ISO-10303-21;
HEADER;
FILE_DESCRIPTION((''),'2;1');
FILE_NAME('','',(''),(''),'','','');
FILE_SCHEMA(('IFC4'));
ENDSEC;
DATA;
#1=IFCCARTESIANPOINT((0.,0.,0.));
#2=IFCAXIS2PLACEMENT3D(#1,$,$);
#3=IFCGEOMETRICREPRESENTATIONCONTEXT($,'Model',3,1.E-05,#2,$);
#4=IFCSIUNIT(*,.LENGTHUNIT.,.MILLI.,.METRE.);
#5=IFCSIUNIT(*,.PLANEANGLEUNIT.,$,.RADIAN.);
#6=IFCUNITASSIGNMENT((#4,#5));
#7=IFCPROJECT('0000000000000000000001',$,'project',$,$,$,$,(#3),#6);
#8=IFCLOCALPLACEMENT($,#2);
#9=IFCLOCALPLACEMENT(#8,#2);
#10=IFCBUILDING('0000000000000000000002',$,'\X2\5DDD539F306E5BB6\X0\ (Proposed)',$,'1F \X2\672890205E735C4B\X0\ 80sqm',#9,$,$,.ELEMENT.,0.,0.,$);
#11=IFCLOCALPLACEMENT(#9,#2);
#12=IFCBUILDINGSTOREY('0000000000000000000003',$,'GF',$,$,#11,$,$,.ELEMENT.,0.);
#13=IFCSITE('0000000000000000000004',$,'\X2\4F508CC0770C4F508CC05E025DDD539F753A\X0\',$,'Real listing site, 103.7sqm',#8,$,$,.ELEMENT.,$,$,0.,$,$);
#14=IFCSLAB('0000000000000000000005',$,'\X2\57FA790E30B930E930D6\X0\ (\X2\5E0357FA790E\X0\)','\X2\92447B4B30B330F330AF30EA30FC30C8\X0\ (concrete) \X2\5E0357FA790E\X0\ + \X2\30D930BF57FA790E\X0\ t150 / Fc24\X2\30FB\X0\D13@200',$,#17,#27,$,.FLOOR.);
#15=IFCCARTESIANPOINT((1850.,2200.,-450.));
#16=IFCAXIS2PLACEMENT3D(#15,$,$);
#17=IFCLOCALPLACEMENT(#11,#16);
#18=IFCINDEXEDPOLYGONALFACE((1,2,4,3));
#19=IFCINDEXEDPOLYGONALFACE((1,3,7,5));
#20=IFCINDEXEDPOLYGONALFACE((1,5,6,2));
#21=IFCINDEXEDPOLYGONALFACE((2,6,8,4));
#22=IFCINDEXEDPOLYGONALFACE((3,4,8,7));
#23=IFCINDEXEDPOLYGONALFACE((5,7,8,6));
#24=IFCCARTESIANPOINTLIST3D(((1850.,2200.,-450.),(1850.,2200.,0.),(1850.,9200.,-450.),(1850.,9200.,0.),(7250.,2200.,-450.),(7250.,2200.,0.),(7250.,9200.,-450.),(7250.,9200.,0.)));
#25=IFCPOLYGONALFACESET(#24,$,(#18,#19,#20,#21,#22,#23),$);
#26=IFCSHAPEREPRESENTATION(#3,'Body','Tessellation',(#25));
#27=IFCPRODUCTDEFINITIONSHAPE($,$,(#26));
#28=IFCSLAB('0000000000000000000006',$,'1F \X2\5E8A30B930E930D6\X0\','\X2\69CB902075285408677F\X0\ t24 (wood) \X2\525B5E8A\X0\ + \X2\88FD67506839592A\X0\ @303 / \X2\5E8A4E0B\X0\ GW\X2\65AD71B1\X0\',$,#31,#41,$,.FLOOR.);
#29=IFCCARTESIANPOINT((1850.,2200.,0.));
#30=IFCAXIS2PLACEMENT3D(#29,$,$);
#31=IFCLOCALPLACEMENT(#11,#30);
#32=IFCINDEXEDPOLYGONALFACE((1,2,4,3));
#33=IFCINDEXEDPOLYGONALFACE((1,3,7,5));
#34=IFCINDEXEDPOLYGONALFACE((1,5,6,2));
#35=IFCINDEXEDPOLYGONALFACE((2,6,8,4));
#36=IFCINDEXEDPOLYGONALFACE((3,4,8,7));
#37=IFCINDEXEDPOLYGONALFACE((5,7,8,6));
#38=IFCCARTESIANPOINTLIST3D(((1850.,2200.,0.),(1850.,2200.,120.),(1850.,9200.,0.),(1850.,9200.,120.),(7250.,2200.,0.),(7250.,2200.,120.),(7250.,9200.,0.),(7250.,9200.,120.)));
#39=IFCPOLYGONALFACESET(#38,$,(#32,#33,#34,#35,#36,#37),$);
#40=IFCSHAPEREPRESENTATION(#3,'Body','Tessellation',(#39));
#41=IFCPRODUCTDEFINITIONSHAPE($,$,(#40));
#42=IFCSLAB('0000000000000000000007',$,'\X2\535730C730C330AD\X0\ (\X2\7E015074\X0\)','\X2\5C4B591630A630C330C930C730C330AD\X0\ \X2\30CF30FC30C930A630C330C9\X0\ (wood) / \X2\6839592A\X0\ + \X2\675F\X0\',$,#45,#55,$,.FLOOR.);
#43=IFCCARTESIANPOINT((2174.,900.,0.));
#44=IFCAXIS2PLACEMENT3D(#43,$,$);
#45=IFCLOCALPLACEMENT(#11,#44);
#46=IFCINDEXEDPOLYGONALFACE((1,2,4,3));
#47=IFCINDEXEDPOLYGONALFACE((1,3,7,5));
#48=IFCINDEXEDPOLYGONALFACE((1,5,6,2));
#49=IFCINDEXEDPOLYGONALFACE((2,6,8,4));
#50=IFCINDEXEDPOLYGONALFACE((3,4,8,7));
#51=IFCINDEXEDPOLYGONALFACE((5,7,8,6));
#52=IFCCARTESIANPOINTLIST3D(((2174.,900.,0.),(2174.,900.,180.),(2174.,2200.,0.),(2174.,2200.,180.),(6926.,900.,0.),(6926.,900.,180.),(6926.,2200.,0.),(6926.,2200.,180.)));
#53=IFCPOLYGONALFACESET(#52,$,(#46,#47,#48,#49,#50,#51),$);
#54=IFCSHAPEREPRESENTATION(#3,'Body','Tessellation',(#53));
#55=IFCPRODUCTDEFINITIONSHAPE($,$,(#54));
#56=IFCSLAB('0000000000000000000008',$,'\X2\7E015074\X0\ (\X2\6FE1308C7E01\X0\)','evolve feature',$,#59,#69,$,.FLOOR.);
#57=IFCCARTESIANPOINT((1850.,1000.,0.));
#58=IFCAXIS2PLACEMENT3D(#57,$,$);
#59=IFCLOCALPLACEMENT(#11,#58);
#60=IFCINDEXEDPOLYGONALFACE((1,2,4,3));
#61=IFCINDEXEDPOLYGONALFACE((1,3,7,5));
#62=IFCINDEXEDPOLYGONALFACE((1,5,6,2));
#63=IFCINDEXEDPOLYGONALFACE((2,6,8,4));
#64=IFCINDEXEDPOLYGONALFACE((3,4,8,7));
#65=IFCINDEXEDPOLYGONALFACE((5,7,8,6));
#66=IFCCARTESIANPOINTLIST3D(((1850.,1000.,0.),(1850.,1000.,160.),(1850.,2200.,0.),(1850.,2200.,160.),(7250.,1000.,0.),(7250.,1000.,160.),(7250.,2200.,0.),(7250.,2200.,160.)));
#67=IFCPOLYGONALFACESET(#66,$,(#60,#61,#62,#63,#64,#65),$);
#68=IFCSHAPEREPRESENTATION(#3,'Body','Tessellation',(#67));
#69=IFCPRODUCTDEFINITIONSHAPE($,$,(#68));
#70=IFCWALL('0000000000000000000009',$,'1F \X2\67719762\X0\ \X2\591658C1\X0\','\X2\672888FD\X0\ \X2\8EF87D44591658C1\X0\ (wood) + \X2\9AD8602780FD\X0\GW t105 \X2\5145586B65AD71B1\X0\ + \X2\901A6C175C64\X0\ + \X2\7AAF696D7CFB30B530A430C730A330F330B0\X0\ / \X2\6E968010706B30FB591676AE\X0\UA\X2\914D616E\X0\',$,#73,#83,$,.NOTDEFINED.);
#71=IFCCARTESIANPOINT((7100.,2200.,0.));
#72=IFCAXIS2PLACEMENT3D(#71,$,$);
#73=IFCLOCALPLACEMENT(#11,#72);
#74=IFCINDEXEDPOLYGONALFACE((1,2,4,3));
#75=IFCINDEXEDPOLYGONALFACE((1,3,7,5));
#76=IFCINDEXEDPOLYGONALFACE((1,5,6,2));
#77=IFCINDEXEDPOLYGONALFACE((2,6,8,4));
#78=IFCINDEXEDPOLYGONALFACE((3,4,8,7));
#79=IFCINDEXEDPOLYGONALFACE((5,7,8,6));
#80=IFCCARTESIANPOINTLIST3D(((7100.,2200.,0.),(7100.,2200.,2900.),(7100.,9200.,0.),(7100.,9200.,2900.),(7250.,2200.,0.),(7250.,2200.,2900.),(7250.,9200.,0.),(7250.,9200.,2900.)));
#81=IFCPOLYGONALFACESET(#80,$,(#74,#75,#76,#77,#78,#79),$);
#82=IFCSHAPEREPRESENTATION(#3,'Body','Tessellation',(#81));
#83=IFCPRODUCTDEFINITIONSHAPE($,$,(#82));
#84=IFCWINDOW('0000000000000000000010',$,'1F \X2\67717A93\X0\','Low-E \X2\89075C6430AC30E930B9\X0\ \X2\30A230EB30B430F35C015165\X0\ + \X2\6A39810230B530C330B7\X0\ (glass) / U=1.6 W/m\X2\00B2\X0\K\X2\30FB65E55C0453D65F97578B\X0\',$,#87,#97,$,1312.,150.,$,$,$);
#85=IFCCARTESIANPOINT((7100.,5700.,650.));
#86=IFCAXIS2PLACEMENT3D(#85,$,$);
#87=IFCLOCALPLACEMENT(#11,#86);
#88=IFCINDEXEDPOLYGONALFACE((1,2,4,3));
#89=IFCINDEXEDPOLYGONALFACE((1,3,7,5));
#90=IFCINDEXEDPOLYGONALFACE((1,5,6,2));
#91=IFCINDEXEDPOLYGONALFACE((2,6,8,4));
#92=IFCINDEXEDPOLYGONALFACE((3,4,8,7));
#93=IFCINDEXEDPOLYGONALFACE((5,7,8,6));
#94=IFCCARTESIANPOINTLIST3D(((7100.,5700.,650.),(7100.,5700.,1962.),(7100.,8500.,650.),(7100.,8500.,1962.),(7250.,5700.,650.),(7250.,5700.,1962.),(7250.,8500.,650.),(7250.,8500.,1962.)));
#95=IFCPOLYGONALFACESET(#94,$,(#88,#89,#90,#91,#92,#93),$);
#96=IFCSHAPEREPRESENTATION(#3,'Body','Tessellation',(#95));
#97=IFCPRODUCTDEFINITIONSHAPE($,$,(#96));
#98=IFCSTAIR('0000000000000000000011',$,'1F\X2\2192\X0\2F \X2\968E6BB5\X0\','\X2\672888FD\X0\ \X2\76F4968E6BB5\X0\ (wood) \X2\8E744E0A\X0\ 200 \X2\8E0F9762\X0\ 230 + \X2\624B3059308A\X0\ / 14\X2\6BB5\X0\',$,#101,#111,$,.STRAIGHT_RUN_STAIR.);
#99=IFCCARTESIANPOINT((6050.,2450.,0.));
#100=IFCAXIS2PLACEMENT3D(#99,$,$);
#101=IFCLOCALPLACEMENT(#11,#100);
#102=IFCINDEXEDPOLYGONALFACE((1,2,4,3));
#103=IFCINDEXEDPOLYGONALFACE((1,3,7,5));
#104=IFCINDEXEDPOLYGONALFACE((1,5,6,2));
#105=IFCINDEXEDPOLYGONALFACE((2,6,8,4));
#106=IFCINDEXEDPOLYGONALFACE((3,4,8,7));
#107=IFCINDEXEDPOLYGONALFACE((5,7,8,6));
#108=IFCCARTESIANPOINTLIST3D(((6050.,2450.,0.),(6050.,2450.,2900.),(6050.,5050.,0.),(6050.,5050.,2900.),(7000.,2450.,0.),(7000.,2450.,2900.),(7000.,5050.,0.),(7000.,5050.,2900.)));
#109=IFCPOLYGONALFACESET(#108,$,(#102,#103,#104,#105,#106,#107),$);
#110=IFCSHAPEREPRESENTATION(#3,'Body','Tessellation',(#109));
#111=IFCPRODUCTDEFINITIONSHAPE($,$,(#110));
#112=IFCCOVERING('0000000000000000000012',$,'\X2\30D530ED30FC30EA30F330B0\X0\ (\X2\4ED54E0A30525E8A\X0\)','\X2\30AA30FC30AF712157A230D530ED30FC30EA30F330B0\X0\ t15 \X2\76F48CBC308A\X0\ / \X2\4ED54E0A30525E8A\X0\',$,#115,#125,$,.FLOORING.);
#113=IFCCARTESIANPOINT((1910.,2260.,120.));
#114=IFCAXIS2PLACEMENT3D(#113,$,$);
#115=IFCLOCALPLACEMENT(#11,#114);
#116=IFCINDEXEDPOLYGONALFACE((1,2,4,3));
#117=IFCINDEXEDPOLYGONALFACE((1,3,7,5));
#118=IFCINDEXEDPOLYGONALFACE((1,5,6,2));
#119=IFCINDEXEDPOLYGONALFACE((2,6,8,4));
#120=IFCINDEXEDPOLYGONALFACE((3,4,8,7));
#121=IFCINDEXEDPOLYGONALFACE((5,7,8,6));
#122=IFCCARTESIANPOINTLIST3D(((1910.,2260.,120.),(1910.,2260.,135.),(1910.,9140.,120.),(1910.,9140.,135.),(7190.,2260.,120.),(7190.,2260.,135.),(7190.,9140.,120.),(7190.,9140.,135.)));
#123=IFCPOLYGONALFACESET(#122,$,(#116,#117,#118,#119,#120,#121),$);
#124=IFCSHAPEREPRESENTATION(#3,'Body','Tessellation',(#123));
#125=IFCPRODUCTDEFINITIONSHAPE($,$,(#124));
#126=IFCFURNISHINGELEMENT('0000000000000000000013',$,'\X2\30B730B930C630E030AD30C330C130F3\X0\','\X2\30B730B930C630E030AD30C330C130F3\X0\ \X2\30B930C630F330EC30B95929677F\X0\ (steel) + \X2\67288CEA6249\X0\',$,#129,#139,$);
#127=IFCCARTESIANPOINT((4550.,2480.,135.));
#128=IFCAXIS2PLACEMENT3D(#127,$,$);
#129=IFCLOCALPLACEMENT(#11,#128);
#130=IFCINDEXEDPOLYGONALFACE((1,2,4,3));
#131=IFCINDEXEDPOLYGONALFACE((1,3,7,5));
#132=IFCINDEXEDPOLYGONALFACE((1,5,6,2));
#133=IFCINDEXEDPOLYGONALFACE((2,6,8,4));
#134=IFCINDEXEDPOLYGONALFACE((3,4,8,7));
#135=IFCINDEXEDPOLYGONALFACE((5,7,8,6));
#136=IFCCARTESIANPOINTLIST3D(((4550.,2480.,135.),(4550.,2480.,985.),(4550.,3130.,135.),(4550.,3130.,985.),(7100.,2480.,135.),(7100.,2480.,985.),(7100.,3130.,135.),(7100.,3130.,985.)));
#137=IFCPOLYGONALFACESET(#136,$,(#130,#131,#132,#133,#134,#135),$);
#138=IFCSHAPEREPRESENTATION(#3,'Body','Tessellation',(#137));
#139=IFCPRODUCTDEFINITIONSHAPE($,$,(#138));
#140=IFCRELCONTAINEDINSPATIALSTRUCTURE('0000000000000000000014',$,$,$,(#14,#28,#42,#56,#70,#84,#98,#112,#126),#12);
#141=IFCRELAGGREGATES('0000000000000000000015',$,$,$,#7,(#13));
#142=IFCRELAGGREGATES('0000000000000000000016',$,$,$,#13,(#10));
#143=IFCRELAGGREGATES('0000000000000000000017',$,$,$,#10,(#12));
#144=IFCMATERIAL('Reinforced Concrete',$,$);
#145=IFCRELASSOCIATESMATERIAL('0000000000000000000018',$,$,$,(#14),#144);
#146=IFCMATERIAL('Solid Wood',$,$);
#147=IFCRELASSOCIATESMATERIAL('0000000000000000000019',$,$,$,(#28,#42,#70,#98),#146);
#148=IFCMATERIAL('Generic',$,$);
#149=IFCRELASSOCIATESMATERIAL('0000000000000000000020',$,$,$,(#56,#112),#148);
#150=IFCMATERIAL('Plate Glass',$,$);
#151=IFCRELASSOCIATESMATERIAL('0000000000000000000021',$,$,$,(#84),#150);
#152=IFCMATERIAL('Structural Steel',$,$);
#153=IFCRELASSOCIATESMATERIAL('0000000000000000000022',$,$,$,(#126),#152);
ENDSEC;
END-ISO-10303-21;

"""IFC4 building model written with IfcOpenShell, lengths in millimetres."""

from ifc_helpers import new_model, si_unit, frame, frame_2d, origin, place, context, project, spatial, rectangle, extrude, material, element, fill, save


model = new_model("IFC4")

# Units and contexts
model_context = context("Model", 3, precision=1e-05, world=origin())
ifc_project = project(units=[si_unit("LENGTHUNIT", "METRE", prefix="MILLI"), si_unit("PLANEANGLEUNIT", "RADIAN")], contexts=[model_context])

# Site, building, storey
site_placement = place(None, origin())
site = spatial("IfcSite", under=ifc_project, at=site_placement, Name="佐賀県佐賀市川原町", ObjectType="Real listing site, 103.7sqm", CompositionType="ELEMENT", RefElevation=0.0)
building_placement = place(site_placement, origin())
building = spatial("IfcBuilding", under=site, at=building_placement, Name="川原の家 (Proposed)", ObjectType="1F 木造平屋 80sqm", CompositionType="ELEMENT", ElevationOfRefHeight=0.0, ElevationOfTerrain=0.0)
storey_placement = place(building_placement, origin())
storey = spatial("IfcBuildingStorey", under=building, at=storey_placement, Name="GF", CompositionType="ELEMENT", Elevation=0.0)

# Slabs
ifc_material_1 = material(Name="Reinforced Concrete")
slab_1_placement = place(storey_placement, frame((1850.0, 2200.0, -450.0)))
element("IfcSlab", 1, at=slab_1_placement, inside=storey, material=ifc_material_1, Name="基礎スラブ (布基礎)", Description="鉄筋コンクリート (concrete) 布基礎 + ベタ基礎 t150 / Fc24・D13@200", PredefinedType="FLOOR", context=model_context, shape_type="SweptSolid", body=[
    extrude(rectangle(XDim=5400.0, YDim=7000.0, at=frame_2d((2700.0, 3500.0))), frame((1850.0, 2200.0, -450.0)), (0.0, 0.0, 1.0), 450.0),
])
ifc_material_2 = material(Name="Solid Wood")
slab_2_placement = place(storey_placement, frame((1850.0, 2200.0, 0.0)))
element("IfcSlab", 2, at=slab_2_placement, inside=storey, material=ifc_material_2, Name="1F 床スラブ", Description="構造用合板 t24 (wood) 剛床 + 製材根太 @303 / 床下 GW断熱", PredefinedType="FLOOR", context=model_context, shape_type="SweptSolid", body=[
    extrude(rectangle(XDim=5400.0, YDim=7000.0, at=frame_2d((2700.0, 3500.0))), frame((1850.0, 2200.0, 0.0)), (0.0, 0.0, 1.0), 120.0),
])
slab_3_placement = place(storey_placement, frame((2174.0, 900.0, 0.0)))
element("IfcSlab", 3, at=slab_3_placement, inside=storey, material=ifc_material_2, Name="南デッキ (縁側)", Description="屋外ウッドデッキ ハードウッド (wood) / 根太 + 束", PredefinedType="FLOOR", context=model_context, shape_type="SweptSolid", body=[
    extrude(rectangle(XDim=4752.0, YDim=1300.0, at=frame_2d((2376.0, 650.0))), frame((2174.0, 900.0, 0.0)), (0.0, 0.0, 1.0), 180.0),
])
ifc_material_3 = material(Name="Generic")
slab_4_placement = place(storey_placement, frame((1850.0, 1000.0, 0.0)))
element("IfcSlab", 4, at=slab_4_placement, inside=storey, material=ifc_material_3, Name="縁側 (濡れ縁)", Description="evolve feature", PredefinedType="FLOOR", context=model_context, shape_type="SweptSolid", body=[
    extrude(rectangle(XDim=5400.0, YDim=1200.0, at=frame_2d((2700.0, 600.0))), frame((1850.0, 1000.0, 0.0)), (0.0, 0.0, 1.0), 160.0),
])

# Shared definitions
ifc_material_4 = material(Name="Plate Glass")

# Wall, opening, window
wall_1_placement = place(storey_placement, frame((7100.0, 2200.0, 0.0)))
wall_1 = element("IfcWall", 5, at=wall_1_placement, inside=storey, material=ifc_material_2, Name="1F 東面 外壁", Description="木製 軸組外壁 (wood) + 高性能GW t105 充填断熱 + 通気層 + 窯業系サイディング / 準耐火・外皮UA配慮", PredefinedType="NOTDEFINED", context=model_context, shape_type="SweptSolid", body=[
    extrude(rectangle(XDim=150.0, YDim=7000.0, at=frame_2d((75.0, 3500.0))), frame((7100.0, 2200.0, 0.0)), (0.0, 0.0, 1.0), 2900.0),
])
opening_1_placement = place(storey_placement, frame((7100.0, 5700.0, 650.0)))
opening_1 = element("IfcOpeningElement", 6, at=opening_1_placement, cuts=wall_1, PredefinedType="NOTDEFINED", context=model_context, shape_type="SweptSolid", body=[
    extrude(rectangle(XDim=150.0, YDim=2800.0, at=frame_2d((75.0, 1400.0))), frame((7100.0, 5700.0, 650.0)), (0.0, 0.0, 1.0), 1312.0),
])
window_1_placement = place(storey_placement, frame((7100.0, 5700.0, 650.0)))
window_1 = element("IfcWindow", 7, at=window_1_placement, inside=storey, material=ifc_material_4, Name="1F 東窓", Description="Low-E 複層ガラス アルゴン封入 + 樹脂サッシ (glass) / U=1.6 W/m²K・日射取得型", OverallHeight=1312.0, OverallWidth=150.0, context=model_context, shape_type="SweptSolid", body=[
    extrude(rectangle(XDim=150.0, YDim=2800.0, at=frame_2d((75.0, 1400.0))), frame((7100.0, 5700.0, 650.0)), (0.0, 0.0, 1.0), 1312.0),
])
fill(opening_1, window_1)

# Stair
stair_placement = place(storey_placement, frame((6050.0, 2450.0, 0.0)))
element("IfcStair", 8, at=stair_placement, inside=storey, material=ifc_material_2, Name="1F→2F 階段", Description="木製 直階段 (wood) 蹴上 200 踏面 230 + 手すり / 14段", PredefinedType="STRAIGHT_RUN_STAIR", context=model_context, shape_type="SweptSolid", body=[
    extrude(rectangle(XDim=950.0, YDim=2600.0, at=frame_2d((475.0, 1300.0))), frame((6050.0, 2450.0, 0.0)), (0.0, 0.0, 1.0), 2900.0),
])

# Covering
covering_placement = place(storey_placement, frame((1910.0, 2260.0, 120.0)))
element("IfcCovering", 9, at=covering_placement, inside=storey, material=ifc_material_3, Name="フローリング (仕上げ床)", Description="オーク無垢フローリング t15 直貼り / 仕上げ床", PredefinedType="FLOORING", context=model_context, shape_type="SweptSolid", body=[
    extrude(rectangle(XDim=5280.0, YDim=6880.0, at=frame_2d((2640.0, 3440.0))), frame((1910.0, 2260.0, 120.0)), (0.0, 0.0, 1.0), 15.0),
])

# Furnishing element
ifc_material_5 = material(Name="Structural Steel")
furnishing_placement = place(storey_placement, frame((4550.0, 2480.0, 135.0)))
element("IfcFurnishingElement", 10, at=furnishing_placement, inside=storey, material=ifc_material_5, Name="システムキッチン", Description="システムキッチン ステンレス天板 (steel) + 木質扉", context=model_context, shape_type="SweptSolid", body=[
    extrude(rectangle(XDim=2550.0, YDim=650.0, at=frame_2d((1275.0, 325.0))), frame((4550.0, 2480.0, 135.0)), (0.0, 0.0, 1.0), 850.0),
])

save(model, "model.ifc")
